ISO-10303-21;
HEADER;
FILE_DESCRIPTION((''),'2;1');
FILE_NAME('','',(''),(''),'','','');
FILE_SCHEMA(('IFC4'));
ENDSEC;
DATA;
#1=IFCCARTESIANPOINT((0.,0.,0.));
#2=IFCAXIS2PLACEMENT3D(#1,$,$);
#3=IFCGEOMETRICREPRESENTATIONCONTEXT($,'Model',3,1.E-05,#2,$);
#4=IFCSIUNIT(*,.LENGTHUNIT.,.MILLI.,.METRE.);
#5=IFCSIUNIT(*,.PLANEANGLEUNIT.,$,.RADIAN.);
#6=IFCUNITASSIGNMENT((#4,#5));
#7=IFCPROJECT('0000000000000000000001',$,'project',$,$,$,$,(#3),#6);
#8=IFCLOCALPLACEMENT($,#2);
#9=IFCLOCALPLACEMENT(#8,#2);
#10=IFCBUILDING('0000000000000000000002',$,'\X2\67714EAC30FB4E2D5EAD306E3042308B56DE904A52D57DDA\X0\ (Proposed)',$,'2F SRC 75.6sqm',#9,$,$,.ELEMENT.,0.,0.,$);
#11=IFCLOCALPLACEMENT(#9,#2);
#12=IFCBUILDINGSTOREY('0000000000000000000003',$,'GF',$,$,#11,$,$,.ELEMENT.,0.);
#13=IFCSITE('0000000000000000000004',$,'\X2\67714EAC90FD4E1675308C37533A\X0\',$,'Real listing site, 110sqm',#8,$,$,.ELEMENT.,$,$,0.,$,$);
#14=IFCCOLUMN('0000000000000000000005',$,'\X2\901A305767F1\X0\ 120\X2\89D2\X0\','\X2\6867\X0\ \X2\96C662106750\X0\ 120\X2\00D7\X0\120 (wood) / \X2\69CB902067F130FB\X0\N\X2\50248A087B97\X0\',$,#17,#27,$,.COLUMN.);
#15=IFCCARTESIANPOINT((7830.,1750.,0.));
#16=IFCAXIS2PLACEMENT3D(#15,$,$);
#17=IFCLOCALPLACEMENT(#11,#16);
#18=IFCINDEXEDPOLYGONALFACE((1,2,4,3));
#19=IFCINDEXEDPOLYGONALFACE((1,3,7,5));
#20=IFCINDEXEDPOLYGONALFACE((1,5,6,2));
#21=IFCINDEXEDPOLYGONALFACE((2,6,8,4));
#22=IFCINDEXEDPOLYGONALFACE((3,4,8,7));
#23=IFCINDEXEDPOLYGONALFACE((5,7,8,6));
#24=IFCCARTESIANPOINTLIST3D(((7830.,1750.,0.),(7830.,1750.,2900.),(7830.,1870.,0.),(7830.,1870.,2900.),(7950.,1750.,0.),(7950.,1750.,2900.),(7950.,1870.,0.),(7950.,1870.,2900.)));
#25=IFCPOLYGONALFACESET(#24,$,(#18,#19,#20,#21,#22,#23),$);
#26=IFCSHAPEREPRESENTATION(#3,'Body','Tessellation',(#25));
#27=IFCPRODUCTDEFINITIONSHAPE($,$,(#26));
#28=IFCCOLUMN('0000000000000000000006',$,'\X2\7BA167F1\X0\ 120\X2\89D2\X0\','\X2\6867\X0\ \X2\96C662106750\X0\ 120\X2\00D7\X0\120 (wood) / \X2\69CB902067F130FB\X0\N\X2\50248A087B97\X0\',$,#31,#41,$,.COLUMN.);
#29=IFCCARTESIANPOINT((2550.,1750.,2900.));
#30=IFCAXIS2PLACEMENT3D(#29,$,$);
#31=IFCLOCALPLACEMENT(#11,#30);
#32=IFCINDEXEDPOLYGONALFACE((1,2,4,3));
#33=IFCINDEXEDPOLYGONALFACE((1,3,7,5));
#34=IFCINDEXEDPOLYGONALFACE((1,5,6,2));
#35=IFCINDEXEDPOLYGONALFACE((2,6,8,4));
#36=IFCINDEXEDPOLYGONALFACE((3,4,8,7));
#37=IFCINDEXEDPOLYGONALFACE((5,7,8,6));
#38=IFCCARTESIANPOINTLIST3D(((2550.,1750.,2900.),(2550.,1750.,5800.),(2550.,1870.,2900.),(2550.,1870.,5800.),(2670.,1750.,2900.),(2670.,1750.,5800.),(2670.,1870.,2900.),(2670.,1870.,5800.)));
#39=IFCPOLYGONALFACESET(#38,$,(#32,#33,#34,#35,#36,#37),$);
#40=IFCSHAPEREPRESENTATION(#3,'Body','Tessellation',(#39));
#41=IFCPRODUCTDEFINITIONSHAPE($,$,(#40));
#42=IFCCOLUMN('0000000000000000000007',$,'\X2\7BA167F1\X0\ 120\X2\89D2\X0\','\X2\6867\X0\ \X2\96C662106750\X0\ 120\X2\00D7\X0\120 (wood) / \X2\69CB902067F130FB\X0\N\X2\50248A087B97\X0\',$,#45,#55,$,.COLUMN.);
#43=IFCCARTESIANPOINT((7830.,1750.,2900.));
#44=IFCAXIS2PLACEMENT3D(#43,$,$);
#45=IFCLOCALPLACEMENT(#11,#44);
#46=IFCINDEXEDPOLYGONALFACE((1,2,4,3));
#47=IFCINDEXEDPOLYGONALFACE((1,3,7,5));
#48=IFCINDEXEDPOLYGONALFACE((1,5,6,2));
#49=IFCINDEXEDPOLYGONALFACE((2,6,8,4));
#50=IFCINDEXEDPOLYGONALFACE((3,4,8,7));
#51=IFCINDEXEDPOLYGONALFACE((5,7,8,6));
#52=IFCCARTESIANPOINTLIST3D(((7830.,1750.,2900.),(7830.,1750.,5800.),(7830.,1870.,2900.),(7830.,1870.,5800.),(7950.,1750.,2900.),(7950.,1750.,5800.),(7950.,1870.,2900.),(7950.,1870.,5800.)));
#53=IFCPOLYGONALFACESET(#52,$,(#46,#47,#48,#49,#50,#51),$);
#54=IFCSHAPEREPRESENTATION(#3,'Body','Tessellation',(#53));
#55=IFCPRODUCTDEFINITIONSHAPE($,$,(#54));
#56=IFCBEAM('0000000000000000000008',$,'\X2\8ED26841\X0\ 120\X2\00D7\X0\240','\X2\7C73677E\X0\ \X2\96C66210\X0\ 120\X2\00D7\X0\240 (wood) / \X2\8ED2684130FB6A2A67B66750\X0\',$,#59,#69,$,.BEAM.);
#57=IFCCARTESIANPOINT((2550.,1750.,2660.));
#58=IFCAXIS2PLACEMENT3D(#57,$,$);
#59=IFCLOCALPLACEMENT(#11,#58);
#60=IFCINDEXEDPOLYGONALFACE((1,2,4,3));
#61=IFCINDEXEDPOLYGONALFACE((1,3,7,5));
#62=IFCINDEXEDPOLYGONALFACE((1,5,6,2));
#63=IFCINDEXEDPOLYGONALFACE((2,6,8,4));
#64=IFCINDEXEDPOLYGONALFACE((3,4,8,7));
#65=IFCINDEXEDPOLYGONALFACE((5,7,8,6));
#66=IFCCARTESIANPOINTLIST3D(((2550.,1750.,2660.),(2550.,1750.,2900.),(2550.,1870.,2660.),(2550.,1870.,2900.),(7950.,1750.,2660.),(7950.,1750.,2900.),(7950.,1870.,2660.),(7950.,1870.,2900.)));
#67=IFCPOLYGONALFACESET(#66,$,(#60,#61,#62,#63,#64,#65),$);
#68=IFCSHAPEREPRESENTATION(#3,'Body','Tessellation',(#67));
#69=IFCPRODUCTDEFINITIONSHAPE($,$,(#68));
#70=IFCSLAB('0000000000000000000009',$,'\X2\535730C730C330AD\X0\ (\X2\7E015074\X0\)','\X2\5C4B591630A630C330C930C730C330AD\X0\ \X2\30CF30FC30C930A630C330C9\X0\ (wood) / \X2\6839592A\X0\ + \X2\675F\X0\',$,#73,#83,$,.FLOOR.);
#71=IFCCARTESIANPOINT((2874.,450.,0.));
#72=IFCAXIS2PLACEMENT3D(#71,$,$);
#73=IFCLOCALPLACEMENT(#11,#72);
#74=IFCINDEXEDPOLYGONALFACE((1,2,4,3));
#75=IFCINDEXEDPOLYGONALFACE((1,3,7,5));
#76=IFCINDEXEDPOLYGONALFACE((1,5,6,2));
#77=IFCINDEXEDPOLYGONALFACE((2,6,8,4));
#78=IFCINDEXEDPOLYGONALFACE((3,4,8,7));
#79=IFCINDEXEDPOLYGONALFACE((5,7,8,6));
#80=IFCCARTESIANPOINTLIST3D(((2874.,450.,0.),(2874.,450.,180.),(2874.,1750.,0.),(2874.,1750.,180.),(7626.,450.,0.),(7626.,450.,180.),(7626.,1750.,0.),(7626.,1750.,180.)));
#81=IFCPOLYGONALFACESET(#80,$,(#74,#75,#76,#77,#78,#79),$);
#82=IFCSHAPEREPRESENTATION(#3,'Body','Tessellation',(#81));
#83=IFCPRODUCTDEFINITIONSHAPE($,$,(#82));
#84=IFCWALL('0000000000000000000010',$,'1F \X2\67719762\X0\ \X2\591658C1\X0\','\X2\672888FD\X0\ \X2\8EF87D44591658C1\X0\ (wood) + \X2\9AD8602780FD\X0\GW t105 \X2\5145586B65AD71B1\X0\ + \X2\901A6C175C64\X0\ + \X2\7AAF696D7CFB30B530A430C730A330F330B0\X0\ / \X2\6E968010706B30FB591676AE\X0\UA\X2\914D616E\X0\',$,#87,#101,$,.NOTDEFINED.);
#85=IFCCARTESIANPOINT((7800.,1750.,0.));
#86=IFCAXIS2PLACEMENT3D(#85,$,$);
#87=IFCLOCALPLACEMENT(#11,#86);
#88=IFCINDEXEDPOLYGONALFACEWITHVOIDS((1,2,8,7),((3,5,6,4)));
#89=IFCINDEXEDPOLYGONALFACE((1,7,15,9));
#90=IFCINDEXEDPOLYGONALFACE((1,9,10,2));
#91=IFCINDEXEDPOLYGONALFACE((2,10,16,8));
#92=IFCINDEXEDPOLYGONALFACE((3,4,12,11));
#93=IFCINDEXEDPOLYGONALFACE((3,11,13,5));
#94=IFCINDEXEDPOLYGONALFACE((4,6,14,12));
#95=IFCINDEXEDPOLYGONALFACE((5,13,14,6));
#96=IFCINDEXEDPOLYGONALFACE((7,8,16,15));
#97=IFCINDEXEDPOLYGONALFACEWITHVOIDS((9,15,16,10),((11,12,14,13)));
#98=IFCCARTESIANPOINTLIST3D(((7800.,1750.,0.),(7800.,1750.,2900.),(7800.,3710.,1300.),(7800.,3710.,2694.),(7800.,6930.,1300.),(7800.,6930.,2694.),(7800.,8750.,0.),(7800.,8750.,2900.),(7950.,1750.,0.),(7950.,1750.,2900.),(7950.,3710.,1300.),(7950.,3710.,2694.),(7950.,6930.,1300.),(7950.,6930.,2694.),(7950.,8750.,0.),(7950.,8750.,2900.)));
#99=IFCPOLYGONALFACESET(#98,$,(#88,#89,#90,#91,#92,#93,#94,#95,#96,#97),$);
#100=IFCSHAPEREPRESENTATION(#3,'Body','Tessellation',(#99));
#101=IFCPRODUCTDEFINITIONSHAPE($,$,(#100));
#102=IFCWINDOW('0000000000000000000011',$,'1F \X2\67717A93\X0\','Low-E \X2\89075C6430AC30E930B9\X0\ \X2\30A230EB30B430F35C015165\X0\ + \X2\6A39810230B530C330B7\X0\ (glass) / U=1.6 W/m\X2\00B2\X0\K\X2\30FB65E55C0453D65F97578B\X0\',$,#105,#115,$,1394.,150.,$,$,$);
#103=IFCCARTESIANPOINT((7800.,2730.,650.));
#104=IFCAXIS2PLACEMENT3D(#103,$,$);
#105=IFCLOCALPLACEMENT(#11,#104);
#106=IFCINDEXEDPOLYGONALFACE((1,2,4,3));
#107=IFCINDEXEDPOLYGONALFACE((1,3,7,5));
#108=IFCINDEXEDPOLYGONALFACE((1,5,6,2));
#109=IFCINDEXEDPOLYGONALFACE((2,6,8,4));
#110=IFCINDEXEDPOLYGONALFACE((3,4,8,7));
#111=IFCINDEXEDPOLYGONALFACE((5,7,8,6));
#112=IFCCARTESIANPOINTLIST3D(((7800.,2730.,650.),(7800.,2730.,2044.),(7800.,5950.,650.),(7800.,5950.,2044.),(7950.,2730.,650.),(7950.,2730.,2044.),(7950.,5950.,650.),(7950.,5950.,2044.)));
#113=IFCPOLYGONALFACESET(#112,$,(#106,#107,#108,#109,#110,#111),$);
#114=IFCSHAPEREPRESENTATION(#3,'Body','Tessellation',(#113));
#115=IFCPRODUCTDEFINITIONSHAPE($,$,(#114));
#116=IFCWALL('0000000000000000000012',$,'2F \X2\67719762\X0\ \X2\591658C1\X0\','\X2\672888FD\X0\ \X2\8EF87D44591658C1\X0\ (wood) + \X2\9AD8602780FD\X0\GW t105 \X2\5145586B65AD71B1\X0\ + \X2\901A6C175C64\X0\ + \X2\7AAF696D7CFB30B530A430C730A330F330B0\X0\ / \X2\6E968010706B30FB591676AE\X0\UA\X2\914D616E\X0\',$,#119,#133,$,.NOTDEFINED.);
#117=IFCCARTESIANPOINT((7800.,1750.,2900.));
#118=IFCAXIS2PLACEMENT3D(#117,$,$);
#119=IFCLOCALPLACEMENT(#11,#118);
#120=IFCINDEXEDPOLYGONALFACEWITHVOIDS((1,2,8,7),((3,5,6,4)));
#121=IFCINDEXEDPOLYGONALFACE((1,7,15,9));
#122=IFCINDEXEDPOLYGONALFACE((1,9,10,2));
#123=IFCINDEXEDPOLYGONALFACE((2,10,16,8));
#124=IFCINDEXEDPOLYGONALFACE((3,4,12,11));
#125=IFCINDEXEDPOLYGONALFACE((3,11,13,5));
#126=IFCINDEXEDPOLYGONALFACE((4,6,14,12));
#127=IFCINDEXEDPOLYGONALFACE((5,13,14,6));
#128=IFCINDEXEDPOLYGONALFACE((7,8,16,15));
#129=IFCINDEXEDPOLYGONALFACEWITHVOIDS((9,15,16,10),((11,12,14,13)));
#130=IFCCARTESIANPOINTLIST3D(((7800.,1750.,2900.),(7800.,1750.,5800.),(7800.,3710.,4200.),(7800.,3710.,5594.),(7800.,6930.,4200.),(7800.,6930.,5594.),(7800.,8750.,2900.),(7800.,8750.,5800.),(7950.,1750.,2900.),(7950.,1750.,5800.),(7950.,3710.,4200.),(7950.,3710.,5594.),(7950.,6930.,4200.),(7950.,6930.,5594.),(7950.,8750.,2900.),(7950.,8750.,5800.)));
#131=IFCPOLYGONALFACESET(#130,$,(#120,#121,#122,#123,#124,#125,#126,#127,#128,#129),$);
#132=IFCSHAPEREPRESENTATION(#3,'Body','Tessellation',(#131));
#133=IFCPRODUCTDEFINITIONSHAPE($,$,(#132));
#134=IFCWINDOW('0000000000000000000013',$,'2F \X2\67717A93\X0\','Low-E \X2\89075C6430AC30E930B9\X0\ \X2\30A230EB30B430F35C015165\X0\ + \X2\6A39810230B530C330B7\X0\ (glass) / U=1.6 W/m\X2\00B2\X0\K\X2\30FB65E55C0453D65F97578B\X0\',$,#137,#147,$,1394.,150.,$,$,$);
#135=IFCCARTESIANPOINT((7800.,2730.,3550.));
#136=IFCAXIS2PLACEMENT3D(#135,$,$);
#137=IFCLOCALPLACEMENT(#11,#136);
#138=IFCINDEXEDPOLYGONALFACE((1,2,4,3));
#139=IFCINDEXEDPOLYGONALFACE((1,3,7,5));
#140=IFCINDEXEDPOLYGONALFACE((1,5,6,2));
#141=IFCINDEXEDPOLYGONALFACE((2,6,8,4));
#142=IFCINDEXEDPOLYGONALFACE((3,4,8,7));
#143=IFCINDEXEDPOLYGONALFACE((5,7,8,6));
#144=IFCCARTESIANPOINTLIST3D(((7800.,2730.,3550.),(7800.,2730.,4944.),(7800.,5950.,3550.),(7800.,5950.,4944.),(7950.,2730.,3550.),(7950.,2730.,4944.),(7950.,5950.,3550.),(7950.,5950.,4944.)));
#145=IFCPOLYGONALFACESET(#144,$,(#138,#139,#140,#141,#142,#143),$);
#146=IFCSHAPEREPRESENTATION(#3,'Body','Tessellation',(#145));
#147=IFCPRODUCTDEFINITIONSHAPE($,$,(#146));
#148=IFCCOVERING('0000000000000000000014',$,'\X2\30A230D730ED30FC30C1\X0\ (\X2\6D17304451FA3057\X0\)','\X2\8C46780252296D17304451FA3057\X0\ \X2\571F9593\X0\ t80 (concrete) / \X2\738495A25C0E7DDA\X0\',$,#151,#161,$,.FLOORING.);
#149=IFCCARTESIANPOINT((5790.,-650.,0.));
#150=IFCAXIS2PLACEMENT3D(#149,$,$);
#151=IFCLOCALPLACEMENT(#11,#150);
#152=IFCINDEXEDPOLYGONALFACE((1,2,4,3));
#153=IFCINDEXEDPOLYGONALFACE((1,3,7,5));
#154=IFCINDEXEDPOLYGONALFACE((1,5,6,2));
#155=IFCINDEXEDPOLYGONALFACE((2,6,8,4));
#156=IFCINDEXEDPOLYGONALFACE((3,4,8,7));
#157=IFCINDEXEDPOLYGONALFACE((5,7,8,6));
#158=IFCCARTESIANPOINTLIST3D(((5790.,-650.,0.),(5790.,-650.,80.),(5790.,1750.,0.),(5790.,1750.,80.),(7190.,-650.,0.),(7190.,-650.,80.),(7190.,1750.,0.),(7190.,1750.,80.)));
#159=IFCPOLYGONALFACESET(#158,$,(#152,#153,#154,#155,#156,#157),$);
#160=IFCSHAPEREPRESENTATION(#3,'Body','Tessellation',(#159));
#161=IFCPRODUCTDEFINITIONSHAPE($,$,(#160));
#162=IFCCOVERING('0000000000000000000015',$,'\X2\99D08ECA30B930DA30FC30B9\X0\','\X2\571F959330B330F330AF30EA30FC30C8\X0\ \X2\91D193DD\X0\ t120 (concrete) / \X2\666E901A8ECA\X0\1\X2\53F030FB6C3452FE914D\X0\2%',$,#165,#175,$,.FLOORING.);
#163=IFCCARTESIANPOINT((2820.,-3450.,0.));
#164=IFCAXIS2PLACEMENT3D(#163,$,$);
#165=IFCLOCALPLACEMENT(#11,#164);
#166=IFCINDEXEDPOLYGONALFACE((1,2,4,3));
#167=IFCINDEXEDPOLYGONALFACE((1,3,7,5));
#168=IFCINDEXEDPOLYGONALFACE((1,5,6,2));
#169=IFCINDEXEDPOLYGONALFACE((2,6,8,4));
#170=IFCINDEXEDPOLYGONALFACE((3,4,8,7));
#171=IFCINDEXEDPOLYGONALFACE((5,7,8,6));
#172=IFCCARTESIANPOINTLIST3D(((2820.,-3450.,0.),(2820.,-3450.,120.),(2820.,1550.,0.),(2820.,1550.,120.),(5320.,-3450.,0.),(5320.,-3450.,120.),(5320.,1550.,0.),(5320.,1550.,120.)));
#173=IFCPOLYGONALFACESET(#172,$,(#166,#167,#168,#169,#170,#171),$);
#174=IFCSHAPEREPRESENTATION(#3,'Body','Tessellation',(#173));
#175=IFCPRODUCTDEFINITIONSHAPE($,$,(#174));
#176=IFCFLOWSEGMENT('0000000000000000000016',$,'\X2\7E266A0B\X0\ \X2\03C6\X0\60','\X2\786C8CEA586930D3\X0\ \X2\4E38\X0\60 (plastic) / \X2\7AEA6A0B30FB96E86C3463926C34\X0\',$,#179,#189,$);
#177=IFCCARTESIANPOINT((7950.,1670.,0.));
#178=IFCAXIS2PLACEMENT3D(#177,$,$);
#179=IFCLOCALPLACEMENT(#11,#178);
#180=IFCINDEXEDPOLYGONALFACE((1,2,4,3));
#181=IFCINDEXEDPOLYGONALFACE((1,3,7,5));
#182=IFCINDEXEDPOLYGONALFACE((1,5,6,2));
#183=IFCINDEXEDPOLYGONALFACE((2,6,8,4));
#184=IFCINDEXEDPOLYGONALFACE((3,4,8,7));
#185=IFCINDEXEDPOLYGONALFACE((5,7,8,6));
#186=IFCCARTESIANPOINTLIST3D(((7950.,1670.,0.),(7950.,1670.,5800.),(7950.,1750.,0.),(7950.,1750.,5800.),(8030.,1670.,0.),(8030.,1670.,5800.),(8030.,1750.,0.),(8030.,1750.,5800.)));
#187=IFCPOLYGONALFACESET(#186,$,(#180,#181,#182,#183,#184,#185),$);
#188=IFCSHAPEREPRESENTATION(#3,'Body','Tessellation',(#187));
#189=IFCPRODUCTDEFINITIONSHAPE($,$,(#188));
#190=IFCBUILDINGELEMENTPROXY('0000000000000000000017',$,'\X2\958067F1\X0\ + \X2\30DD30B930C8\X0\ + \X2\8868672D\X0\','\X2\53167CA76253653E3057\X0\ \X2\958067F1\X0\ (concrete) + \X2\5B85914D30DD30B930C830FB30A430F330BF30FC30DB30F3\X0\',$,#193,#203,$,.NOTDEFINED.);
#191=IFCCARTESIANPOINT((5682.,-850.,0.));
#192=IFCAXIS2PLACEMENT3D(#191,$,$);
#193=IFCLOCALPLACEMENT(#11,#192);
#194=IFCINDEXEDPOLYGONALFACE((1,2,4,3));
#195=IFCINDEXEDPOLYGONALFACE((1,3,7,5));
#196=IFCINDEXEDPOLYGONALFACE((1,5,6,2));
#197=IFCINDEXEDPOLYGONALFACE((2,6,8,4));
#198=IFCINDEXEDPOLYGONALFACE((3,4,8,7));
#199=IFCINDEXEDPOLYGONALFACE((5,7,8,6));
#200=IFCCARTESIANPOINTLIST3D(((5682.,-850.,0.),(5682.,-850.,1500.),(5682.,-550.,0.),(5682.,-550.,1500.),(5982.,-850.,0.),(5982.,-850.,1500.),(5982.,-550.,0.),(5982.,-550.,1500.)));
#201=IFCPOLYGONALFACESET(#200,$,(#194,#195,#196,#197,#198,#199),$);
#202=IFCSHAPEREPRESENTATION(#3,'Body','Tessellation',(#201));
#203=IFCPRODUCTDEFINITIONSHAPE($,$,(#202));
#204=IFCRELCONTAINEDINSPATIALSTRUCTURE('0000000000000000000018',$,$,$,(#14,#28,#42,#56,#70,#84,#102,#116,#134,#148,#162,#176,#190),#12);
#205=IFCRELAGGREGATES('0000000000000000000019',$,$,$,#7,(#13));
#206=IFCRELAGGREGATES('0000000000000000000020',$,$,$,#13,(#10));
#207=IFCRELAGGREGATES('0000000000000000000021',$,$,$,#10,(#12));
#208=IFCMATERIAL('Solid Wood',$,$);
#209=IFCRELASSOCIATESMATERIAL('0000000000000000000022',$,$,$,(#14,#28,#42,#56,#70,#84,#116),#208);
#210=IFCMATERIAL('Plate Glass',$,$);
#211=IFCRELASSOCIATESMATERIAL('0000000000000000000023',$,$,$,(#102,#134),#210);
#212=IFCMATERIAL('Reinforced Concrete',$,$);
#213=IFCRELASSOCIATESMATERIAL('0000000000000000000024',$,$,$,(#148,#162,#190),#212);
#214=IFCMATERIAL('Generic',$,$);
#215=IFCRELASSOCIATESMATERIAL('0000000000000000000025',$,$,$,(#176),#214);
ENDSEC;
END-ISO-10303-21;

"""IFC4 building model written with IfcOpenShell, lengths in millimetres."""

from ifc_helpers import new_model, si_unit, frame, frame_2d, origin, place, context, project, spatial, rectangle, extrude, material, element, fill, save


model = new_model("IFC4")

# Units and contexts
model_context = context("Model", 3, precision=1e-05, world=origin())
ifc_project = project(units=[si_unit("LENGTHUNIT", "METRE", prefix="MILLI"), si_unit("PLANEANGLEUNIT", "RADIAN")], contexts=[model_context])

# Site, building, storey
site_placement = place(None, origin())
site = spatial("IfcSite", under=ifc_project, at=site_placement, Name="東京都世田谷区", ObjectType="Real listing site, 110sqm", CompositionType="ELEMENT", RefElevation=0.0)
building_placement = place(site_placement, origin())
building = spatial("IfcBuilding", under=site, at=building_placement, Name="東京・中庭のある回遊動線 (Proposed)", ObjectType="2F SRC 75.6sqm", CompositionType="ELEMENT", ElevationOfRefHeight=0.0, ElevationOfTerrain=0.0)
storey_placement = place(building_placement, origin())
storey = spatial("IfcBuildingStorey", under=building, at=storey_placement, Name="GF", CompositionType="ELEMENT", Elevation=0.0)

# Columns
ifc_material_1 = material(Name="Solid Wood")
column_1_placement = place(storey_placement, frame((7830.0, 1750.0, 0.0)))
element("IfcColumn", 1, at=column_1_placement, inside=storey, material=ifc_material_1, Name="通し柱 120角", Description="桧 集成材 120×120 (wood) / 構造柱・N値計算", PredefinedType="COLUMN", context=model_context, shape_type="SweptSolid", body=[
    extrude(rectangle(XDim=120.0, YDim=120.0, at=frame_2d((60.0, 60.0))), frame((7830.0, 1750.0, 0.0)), (0.0, 0.0, 1.0), 2900.0),
])
column_2_placement = place(storey_placement, frame((2550.0, 1750.0, 2900.0)))
element("IfcColumn", 2, at=column_2_placement, inside=storey, material=ifc_material_1, Name="管柱 120角", Description="桧 集成材 120×120 (wood) / 構造柱・N値計算", PredefinedType="COLUMN", context=model_context, shape_type="SweptSolid", body=[
    extrude(rectangle(XDim=120.0, YDim=120.0, at=frame_2d((60.0, 60.0))), frame((2550.0, 1750.0, 2900.0)), (0.0, 0.0, 1.0), 2900.0),
])
column_3_placement = place(storey_placement, frame((7830.0, 1750.0, 2900.0)))
element("IfcColumn", 3, at=column_3_placement, inside=storey, material=ifc_material_1, Name="管柱 120角", Description="桧 集成材 120×120 (wood) / 構造柱・N値計算", PredefinedType="COLUMN", context=model_context, shape_type="SweptSolid", body=[
    extrude(rectangle(XDim=120.0, YDim=120.0, at=frame_2d((60.0, 60.0))), frame((7830.0, 1750.0, 2900.0)), (0.0, 0.0, 1.0), 2900.0),
])

# Beam
beam_1_placement = place(storey_placement, frame((2550.0, 1750.0, 2660.0)))
element("IfcBeam", 4, at=beam_1_placement, inside=storey, material=ifc_material_1, Name="軒桁 120×240", Description="米松 集成 120×240 (wood) / 軒桁・横架材", PredefinedType="BEAM", context=model_context, shape_type="SweptSolid", body=[
    extrude(rectangle(XDim=5400.0, YDim=120.0, at=frame_2d((2700.0, 60.0))), frame((2550.0, 1750.0, 2660.0)), (0.0, 0.0, 1.0), 240.0),
])

# Slab
slab_placement = place(storey_placement, frame((2874.0, 450.0, 0.0)))
element("IfcSlab", 5, at=slab_placement, inside=storey, material=ifc_material_1, Name="南デッキ (縁側)", Description="屋外ウッドデッキ ハードウッド (wood) / 根太 + 束", PredefinedType="FLOOR", context=model_context, shape_type="SweptSolid", body=[
    extrude(rectangle(XDim=4752.0, YDim=1300.0, at=frame_2d((2376.0, 650.0))), frame((2874.0, 450.0, 0.0)), (0.0, 0.0, 1.0), 180.0),
])

# Walls, openings, windows
wall_1_placement = place(storey_placement, frame((7800.0, 1750.0, 0.0)))
wall_1 = element("IfcWall", 6, at=wall_1_placement, inside=storey, material=ifc_material_1, Name="1F 東面 外壁", Description="木製 軸組外壁 (wood) + 高性能GW t105 充填断熱 + 通気層 + 窯業系サイディング / 準耐火・外皮UA配慮", PredefinedType="NOTDEFINED", context=model_context, shape_type="SweptSolid", body=[
    extrude(rectangle(XDim=150.0, YDim=7000.0, at=frame_2d((75.0, 3500.0))), frame((7800.0, 1750.0, 0.0)), (0.0, 0.0, 1.0), 2900.0),
])
opening_1_placement = place(storey_placement, frame((7800.0, 2730.0, 650.0)))
opening_1 = element("IfcOpeningElement", 7, at=opening_1_placement, cuts=wall_1, PredefinedType="NOTDEFINED", context=model_context, shape_type="SweptSolid", body=[
    extrude(rectangle(XDim=150.0, YDim=3220.0, at=frame_2d((75.0, 1610.0))), frame((7800.0, 2730.0, 650.0)), (0.0, 0.0, 1.0), 1394.0),
])
ifc_material_2 = material(Name="Plate Glass")
window_1_placement = place(storey_placement, frame((7800.0, 2730.0, 650.0)))
window_1 = element("IfcWindow", 8, at=window_1_placement, inside=storey, material=ifc_material_2, Name="1F 東窓", Description="Low-E 複層ガラス アルゴン封入 + 樹脂サッシ (glass) / U=1.6 W/m²K・日射取得型", OverallHeight=1394.0, OverallWidth=150.0, context=model_context, shape_type="SweptSolid", body=[
    extrude(rectangle(XDim=150.0, YDim=3220.0, at=frame_2d((75.0, 1610.0))), frame((7800.0, 2730.0, 650.0)), (0.0, 0.0, 1.0), 1394.0),
])
fill(opening_1, window_1)
wall_2_placement = place(storey_placement, frame((7800.0, 1750.0, 2900.0)))
wall_2 = element("IfcWall", 9, at=wall_2_placement, inside=storey, material=ifc_material_1, Name="2F 東面 外壁", Description="木製 軸組外壁 (wood) + 高性能GW t105 充填断熱 + 通気層 + 窯業系サイディング / 準耐火・外皮UA配慮", PredefinedType="NOTDEFINED", context=model_context, shape_type="SweptSolid", body=[
    extrude(rectangle(XDim=150.0, YDim=7000.0, at=frame_2d((75.0, 3500.0))), frame((7800.0, 1750.0, 2900.0)), (0.0, 0.0, 1.0), 2900.0),
])
opening_2_placement = place(storey_placement, frame((7800.0, 2730.0, 3550.0)))
opening_2 = element("IfcOpeningElement", 10, at=opening_2_placement, cuts=wall_2, PredefinedType="NOTDEFINED", context=model_context, shape_type="SweptSolid", body=[
    extrude(rectangle(XDim=150.0, YDim=3220.0, at=frame_2d((75.0, 1610.0))), frame((7800.0, 2730.0, 3550.0)), (0.0, 0.0, 1.0), 1394.0),
])
window_2_placement = place(storey_placement, frame((7800.0, 2730.0, 3550.0)))
window_2 = element("IfcWindow", 11, at=window_2_placement, inside=storey, material=ifc_material_2, Name="2F 東窓", Description="Low-E 複層ガラス アルゴン封入 + 樹脂サッシ (glass) / U=1.6 W/m²K・日射取得型", OverallHeight=1394.0, OverallWidth=150.0, context=model_context, shape_type="SweptSolid", body=[
    extrude(rectangle(XDim=150.0, YDim=3220.0, at=frame_2d((75.0, 1610.0))), frame((7800.0, 2730.0, 3550.0)), (0.0, 0.0, 1.0), 1394.0),
])
fill(opening_2, window_2)

# Coverings
ifc_material_3 = material(Name="Reinforced Concrete")
covering_1_placement = place(storey_placement, frame((5790.0, -650.0, 0.0)))
element("IfcCovering", 12, at=covering_1_placement, inside=storey, material=ifc_material_3, Name="アプローチ (洗い出し)", Description="豆砂利洗い出し 土間 t80 (concrete) / 玄関導線", PredefinedType="FLOORING", context=model_context, shape_type="SweptSolid", body=[
    extrude(rectangle(XDim=1400.0, YDim=2400.0, at=frame_2d((700.0, 1200.0))), frame((5790.0, -650.0, 0.0)), (0.0, 0.0, 1.0), 80.0),
])
covering_2_placement = place(storey_placement, frame((2820.0, -3450.0, 0.0)))
element("IfcCovering", 13, at=covering_2_placement, inside=storey, material=ifc_material_3, Name="駐車スペース", Description="土間コンクリート 金鏝 t120 (concrete) / 普通車1台・水勾配2%", PredefinedType="FLOORING", context=model_context, shape_type="SweptSolid", body=[
    extrude(rectangle(XDim=2500.0, YDim=5000.0, at=frame_2d((1250.0, 2500.0))), frame((2820.0, -3450.0, 0.0)), (0.0, 0.0, 1.0), 120.0),
])

# Flow segment
ifc_material_4 = material(Name="Generic")
flow_segment_placement = place(storey_placement, frame((7950.0, 1670.0, 0.0)))
element("IfcFlowSegment", 14, at=flow_segment_placement, inside=storey, material=ifc_material_4, Name="縦樋 φ60", Description="硬質塩ビ 丸60 (plastic) / 竪樋・雨水排水", context=model_context, shape_type="SweptSolid", body=[
    extrude(rectangle(XDim=80.0, YDim=80.0, at=frame_2d((40.0, 40.0))), frame((7950.0, 1670.0, 0.0)), (0.0, 0.0, 1.0), 5800.0),
])

# Building element proxy
proxy_placement = place(storey_placement, frame((5682.0, -850.0, 0.0)))
element("IfcBuildingElementProxy", 15, at=proxy_placement, inside=storey, material=ifc_material_3, Name="門柱 + ポスト + 表札", Description="化粧打放し 門柱 (concrete) + 宅配ポスト・インターホン", PredefinedType="NOTDEFINED", context=model_context, shape_type="SweptSolid", body=[
    extrude(rectangle(XDim=300.0, YDim=300.0, at=frame_2d((150.0, 150.0))), frame((5682.0, -850.0, 0.0)), (0.0, 0.0, 1.0), 1500.0),
])

save(model, "model.ifc")
